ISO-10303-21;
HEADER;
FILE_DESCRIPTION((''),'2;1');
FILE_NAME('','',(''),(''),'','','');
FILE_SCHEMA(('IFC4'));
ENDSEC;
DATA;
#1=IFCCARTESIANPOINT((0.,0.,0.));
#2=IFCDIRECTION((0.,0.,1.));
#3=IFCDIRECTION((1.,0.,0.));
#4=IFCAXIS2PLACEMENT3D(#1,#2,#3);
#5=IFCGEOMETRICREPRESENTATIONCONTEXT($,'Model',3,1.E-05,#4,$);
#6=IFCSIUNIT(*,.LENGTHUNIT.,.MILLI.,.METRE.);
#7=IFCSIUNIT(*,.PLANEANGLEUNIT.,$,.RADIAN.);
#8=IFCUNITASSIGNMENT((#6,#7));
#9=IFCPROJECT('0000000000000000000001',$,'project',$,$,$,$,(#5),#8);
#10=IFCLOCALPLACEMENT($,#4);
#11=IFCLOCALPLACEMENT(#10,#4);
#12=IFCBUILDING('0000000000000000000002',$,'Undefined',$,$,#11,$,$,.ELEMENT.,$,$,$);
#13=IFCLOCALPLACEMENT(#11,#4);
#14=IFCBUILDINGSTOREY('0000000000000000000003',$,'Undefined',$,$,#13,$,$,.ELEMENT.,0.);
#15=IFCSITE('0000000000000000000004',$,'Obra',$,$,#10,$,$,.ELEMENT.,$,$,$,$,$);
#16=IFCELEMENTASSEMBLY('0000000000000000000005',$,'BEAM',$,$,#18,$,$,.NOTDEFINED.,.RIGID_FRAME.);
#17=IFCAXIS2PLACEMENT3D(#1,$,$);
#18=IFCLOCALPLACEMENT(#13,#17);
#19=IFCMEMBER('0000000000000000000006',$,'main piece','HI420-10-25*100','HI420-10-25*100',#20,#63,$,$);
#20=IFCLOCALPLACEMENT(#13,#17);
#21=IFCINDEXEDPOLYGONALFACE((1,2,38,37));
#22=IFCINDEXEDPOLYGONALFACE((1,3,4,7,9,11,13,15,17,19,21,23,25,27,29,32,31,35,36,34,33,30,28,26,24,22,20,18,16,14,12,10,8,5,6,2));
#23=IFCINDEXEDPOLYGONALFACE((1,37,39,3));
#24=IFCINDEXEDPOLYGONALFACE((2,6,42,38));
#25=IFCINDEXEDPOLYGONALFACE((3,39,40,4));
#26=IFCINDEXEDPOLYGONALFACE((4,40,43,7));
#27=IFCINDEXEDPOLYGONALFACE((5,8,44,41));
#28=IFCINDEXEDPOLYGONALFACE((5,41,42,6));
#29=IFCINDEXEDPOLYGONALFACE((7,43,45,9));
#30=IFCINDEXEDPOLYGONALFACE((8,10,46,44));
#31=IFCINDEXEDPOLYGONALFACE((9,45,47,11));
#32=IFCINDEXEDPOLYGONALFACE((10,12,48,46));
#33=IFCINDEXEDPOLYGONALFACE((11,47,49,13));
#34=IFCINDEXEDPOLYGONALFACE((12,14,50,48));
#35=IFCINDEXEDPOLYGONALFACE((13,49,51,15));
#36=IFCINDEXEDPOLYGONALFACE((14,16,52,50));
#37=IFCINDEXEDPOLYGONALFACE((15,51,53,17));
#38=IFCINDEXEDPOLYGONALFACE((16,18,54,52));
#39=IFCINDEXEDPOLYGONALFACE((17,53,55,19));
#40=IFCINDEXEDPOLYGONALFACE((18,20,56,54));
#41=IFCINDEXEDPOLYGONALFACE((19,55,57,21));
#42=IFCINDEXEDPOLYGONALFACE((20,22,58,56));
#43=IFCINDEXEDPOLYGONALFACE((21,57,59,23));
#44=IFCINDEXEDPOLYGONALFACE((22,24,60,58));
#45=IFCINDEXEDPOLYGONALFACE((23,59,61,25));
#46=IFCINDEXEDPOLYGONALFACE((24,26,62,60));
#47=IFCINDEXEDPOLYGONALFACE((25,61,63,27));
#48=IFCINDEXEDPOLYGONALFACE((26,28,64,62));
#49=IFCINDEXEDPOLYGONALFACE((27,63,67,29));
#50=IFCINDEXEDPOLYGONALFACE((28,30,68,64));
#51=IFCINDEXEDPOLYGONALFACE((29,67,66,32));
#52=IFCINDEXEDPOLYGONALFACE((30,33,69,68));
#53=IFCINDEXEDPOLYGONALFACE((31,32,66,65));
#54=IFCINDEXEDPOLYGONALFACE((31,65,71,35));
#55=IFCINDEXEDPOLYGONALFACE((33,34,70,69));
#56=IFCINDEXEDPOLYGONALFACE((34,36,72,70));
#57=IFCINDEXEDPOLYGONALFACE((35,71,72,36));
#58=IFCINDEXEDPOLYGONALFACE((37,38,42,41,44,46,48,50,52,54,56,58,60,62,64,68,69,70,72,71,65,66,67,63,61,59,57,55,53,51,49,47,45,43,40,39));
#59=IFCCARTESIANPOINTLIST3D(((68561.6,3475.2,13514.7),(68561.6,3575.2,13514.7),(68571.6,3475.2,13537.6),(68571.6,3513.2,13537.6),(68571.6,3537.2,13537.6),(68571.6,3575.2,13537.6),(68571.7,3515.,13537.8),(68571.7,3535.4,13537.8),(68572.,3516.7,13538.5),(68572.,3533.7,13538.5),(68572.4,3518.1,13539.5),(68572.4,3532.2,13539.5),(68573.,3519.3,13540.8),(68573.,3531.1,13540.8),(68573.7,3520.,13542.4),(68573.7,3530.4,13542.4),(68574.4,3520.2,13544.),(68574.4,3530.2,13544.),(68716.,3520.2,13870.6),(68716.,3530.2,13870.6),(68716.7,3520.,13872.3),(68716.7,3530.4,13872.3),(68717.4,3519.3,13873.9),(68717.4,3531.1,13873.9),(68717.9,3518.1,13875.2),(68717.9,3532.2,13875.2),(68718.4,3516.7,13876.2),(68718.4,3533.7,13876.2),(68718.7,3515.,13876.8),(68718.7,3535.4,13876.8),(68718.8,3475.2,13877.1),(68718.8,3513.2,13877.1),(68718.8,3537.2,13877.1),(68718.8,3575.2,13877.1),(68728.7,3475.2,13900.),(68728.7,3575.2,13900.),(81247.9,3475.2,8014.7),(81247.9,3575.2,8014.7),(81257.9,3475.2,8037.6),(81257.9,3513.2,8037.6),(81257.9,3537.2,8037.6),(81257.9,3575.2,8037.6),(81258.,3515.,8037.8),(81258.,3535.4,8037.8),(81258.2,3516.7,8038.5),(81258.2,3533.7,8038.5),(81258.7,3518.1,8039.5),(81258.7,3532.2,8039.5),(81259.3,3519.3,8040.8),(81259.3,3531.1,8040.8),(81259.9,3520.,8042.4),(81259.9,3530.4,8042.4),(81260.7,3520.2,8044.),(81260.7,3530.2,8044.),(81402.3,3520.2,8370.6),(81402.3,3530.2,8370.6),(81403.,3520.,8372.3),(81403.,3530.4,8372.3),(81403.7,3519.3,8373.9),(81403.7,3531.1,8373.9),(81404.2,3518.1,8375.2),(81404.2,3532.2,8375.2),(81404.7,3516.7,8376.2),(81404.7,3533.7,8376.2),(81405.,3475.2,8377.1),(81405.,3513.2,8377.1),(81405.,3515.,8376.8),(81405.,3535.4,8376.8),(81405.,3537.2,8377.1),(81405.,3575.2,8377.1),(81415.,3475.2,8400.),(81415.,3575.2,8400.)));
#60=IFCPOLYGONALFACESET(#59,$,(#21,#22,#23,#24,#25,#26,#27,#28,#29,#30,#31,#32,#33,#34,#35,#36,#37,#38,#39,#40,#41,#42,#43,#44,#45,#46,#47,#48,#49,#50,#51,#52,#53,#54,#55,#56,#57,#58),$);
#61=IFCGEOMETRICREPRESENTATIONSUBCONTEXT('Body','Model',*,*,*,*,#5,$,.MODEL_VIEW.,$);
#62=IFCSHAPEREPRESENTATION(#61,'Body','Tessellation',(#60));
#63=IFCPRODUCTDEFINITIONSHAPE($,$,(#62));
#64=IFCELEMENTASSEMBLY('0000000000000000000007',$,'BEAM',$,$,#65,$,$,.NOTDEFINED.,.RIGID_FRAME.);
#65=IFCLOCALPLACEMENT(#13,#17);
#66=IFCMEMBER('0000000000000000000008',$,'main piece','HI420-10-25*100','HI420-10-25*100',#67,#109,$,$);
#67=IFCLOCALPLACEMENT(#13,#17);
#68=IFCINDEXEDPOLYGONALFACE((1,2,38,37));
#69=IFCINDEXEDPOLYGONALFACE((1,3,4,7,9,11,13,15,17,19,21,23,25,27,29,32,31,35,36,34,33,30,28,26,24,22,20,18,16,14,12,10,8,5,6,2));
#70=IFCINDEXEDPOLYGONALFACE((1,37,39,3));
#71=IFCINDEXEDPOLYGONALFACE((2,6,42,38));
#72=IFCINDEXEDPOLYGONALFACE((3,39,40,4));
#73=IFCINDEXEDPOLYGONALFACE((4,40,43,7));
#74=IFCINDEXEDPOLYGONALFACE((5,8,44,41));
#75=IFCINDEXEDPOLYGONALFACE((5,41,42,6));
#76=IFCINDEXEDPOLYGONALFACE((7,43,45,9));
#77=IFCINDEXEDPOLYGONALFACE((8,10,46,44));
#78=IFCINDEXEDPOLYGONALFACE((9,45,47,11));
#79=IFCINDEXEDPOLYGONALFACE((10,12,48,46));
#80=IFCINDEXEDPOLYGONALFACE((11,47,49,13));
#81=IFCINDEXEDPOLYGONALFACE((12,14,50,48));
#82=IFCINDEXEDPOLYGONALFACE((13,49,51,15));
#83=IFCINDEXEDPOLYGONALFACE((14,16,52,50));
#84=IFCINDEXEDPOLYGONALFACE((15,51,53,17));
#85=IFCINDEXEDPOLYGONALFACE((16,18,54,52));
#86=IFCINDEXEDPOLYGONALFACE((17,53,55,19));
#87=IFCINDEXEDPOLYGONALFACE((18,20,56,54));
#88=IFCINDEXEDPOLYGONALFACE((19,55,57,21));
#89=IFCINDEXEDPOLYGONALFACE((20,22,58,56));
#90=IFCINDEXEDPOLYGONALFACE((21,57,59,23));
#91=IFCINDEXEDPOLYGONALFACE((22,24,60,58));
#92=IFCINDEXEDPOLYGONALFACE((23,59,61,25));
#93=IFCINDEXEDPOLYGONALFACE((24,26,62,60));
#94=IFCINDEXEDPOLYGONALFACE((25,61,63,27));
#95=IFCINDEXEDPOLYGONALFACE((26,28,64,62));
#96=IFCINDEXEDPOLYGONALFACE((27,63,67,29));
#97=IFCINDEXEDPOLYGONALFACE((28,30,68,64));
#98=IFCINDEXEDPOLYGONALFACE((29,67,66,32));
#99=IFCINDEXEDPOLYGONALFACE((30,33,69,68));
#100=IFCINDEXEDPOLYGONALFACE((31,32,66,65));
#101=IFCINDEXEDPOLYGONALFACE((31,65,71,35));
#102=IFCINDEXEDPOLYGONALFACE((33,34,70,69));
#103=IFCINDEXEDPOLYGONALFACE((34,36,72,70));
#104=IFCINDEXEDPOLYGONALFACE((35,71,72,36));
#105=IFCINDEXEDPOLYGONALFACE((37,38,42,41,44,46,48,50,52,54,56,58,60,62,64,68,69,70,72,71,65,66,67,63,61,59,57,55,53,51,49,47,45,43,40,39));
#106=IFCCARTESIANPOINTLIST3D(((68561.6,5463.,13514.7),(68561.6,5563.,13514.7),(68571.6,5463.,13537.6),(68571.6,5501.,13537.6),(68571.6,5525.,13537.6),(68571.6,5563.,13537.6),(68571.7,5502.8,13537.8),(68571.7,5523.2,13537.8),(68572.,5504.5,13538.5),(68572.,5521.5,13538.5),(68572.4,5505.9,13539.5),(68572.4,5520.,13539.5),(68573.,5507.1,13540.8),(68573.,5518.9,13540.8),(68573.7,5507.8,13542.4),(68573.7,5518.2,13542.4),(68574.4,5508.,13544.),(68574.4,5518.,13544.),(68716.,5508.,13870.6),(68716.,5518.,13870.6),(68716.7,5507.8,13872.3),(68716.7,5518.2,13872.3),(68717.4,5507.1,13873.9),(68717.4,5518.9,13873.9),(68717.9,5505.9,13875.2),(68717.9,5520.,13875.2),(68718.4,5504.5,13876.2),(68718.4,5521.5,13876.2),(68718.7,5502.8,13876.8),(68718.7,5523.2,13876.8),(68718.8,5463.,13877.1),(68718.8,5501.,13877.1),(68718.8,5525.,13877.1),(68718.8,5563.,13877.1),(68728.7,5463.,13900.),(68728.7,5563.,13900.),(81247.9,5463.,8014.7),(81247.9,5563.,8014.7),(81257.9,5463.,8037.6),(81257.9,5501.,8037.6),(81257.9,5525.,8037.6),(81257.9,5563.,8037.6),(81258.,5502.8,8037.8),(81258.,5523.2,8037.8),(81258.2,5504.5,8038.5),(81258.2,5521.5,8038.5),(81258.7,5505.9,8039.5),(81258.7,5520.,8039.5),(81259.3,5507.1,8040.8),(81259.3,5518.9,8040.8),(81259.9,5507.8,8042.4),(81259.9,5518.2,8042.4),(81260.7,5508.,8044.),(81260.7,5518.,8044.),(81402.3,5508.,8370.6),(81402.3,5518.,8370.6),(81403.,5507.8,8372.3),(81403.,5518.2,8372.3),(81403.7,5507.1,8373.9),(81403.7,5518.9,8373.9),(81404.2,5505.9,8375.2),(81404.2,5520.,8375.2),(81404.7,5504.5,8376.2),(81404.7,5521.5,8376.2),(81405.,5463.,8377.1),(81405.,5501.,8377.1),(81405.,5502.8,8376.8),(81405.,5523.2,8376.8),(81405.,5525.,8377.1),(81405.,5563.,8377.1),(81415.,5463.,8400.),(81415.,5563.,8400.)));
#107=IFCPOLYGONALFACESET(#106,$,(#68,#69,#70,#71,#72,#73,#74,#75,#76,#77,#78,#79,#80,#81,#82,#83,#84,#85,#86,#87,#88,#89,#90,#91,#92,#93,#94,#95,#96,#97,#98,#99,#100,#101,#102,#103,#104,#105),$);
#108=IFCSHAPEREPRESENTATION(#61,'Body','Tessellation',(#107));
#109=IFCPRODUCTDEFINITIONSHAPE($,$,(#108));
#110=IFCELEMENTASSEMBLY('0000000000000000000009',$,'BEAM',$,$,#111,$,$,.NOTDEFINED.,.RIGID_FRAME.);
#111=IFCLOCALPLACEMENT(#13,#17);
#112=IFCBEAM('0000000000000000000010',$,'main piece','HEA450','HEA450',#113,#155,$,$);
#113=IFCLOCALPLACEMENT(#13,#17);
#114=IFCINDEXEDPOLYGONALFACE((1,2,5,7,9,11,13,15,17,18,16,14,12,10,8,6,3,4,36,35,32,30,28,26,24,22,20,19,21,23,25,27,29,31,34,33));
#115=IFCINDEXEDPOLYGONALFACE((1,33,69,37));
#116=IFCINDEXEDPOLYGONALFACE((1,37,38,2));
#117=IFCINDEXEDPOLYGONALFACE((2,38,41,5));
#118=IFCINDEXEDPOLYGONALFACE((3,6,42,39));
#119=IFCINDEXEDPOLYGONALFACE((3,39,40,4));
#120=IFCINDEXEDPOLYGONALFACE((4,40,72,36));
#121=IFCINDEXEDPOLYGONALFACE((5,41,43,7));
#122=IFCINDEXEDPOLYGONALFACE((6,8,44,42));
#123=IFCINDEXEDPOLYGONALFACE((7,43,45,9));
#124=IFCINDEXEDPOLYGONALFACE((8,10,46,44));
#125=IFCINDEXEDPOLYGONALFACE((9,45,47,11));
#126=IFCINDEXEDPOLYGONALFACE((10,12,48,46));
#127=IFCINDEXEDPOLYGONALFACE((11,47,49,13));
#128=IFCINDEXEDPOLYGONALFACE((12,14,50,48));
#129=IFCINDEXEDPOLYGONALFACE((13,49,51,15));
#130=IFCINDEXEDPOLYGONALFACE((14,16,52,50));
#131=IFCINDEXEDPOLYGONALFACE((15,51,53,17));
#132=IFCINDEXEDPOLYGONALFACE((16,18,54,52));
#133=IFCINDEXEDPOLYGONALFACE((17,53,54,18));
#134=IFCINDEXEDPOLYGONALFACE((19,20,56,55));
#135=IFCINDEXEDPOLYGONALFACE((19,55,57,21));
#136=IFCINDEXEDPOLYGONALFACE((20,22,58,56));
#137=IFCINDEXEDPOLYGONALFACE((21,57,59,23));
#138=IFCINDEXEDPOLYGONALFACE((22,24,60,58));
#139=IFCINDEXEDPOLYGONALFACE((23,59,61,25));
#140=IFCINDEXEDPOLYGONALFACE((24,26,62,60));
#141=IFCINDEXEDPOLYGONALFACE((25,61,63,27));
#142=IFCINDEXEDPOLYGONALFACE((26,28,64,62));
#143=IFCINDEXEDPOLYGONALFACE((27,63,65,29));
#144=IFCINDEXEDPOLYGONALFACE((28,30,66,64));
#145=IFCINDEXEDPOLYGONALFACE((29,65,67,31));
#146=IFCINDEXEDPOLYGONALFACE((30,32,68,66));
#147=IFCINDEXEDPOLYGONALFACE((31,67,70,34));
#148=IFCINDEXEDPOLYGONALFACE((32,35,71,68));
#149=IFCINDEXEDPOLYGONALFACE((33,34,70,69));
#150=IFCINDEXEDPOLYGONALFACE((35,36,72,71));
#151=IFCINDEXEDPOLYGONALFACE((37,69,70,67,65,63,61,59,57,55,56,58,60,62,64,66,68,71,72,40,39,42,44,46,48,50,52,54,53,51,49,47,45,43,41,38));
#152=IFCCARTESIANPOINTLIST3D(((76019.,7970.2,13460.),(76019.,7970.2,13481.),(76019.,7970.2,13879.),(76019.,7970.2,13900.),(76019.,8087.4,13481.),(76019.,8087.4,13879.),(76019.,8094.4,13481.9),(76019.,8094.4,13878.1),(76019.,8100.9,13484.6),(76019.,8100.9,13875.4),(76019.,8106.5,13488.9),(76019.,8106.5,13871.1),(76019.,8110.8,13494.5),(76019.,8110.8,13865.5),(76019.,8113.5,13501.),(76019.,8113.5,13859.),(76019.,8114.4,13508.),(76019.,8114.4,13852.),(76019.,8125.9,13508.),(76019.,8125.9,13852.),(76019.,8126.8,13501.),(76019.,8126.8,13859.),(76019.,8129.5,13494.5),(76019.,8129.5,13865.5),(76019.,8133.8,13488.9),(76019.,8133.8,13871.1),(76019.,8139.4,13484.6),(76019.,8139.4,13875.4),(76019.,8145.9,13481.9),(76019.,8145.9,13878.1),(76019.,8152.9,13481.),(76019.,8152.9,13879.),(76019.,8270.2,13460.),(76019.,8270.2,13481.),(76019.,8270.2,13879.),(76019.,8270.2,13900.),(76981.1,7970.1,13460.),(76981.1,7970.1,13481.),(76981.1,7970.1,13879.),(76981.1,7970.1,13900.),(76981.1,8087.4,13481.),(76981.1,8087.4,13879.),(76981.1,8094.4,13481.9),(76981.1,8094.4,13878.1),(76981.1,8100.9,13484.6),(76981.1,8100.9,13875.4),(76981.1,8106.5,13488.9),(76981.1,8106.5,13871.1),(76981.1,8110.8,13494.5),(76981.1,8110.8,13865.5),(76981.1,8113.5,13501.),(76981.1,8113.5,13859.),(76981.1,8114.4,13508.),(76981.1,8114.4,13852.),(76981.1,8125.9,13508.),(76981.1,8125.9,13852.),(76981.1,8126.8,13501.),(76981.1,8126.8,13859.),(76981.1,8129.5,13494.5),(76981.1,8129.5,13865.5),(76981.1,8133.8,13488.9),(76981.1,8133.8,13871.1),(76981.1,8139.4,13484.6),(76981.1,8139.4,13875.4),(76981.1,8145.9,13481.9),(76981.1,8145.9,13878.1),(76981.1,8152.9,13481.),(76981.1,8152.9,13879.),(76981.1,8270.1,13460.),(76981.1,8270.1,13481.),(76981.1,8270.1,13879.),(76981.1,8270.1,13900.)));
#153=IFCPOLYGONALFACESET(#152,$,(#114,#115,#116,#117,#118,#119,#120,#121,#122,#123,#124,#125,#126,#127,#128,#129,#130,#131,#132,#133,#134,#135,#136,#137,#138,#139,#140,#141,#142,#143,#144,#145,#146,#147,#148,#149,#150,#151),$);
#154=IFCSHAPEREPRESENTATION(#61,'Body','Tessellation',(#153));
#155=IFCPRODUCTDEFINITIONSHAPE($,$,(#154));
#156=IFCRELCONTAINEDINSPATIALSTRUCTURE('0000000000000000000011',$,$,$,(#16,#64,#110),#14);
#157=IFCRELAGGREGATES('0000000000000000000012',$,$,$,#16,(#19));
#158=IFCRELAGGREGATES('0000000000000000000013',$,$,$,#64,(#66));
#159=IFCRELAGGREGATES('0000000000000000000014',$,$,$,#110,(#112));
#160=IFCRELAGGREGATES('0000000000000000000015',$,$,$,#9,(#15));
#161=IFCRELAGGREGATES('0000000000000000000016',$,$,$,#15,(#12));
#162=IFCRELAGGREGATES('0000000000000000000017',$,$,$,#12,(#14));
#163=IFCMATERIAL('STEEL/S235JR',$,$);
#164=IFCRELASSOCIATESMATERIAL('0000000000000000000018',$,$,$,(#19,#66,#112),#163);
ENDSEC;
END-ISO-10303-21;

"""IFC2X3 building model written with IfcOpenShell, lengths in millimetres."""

from ifc_helpers import new_model, si_unit, frame, origin_with_axes, origin_2d_with_axis, place, context, subcontext, project, spatial, i_section, extrude, clip, halfspace, material, element, aggregate, save


model = new_model("IFC2X3")

# Units and contexts
model_context = context("Model", 3, precision=1e-05, world=origin_with_axes())
body_context = subcontext(model_context, "Body", "Model", "MODEL_VIEW")
ifc_project = project(units=[si_unit("LENGTHUNIT", "METRE", prefix="MILLI"), si_unit("PLANEANGLEUNIT", "RADIAN")], contexts=[model_context])

# Site, building, storey
site_placement = place(None, origin_with_axes())
site = spatial("IfcSite", under=ifc_project, at=site_placement, Name="Obra", CompositionType="ELEMENT")
building_placement = place(site_placement, origin_with_axes())
building = spatial("IfcBuilding", under=site, at=building_placement, Name="Undefined", CompositionType="ELEMENT")
storey_placement = place(building_placement, origin_with_axes())
storey = spatial("IfcBuildingStorey", under=building, at=storey_placement, Name="Undefined", CompositionType="ELEMENT", Elevation=0.0)

# Element assemblies, members
assembly_1_placement = place(storey_placement, origin_with_axes())
assembly_1 = element("IfcElementAssembly", 1, at=assembly_1_placement, inside=storey, Name="BEAM", AssemblyPlace="NOTDEFINED", PredefinedType="RIGID_FRAME")
ifc_material_1 = material(Name="STEEL/S235JR")
member_1_placement = place(assembly_1_placement, frame((68645.2, 3525.2, 13707.3), z_axis=(0.397766, 0.0, 0.917487), x_axis=(0.917487, 0.0, -0.397766)))
member_1 = element("IfcMember", 2, at=member_1_placement, material=ifc_material_1, Name="main piece", Description="HI420-10-25*100", ObjectType="HI420-10-25*100", context=body_context, shape_type="SweptSolid", body=[
    extrude(i_section(OverallWidth=100.0, OverallDepth=420.0, WebThickness=10.0, FlangeThickness=25.0, FilletRadius=7.0, at=origin_2d_with_axis()), frame((13827.2, 0.0, 0.0), z_axis=(-1.0, 0.0, 0.0), x_axis=(0.0, -1.0, 0.0)), (0.0, 0.0, 1.0), 13827.2),
])
aggregate(assembly_1, [member_1])
assembly_2_placement = place(storey_placement, origin_with_axes())
assembly_2 = element("IfcElementAssembly", 3, at=assembly_2_placement, inside=storey, Name="BEAM", AssemblyPlace="NOTDEFINED", PredefinedType="RIGID_FRAME")
member_2_placement = place(assembly_2_placement, frame((68645.2, 5513.0, 13707.3), z_axis=(0.397766, 0.0, 0.917487), x_axis=(0.917487, 0.0, -0.397766)))
member_2 = element("IfcMember", 4, at=member_2_placement, material=ifc_material_1, Name="main piece", Description="HI420-10-25*100", ObjectType="HI420-10-25*100", context=body_context, shape_type="SweptSolid", body=[
    extrude(i_section(OverallWidth=100.0, OverallDepth=420.0, WebThickness=10.0, FlangeThickness=25.0, FilletRadius=7.0, at=origin_2d_with_axis()), frame((13827.2, 0.0, 0.0), z_axis=(-1.0, 0.0, 0.0), x_axis=(0.0, -1.0, 0.0)), (0.0, 0.0, 1.0), 13827.2),
])
aggregate(assembly_2, [member_2])

# Element assembly, beam
assembly_3_placement = place(storey_placement, origin_with_axes())
assembly_3 = element("IfcElementAssembly", 5, at=assembly_3_placement, inside=storey, Name="BEAM", AssemblyPlace="NOTDEFINED", PredefinedType="RIGID_FRAME")
beam_1_placement = place(assembly_3_placement, frame((76019.0, 8120.2, 13680.0), z_axis=(0.0, 0.0, 1.0), x_axis=(1.0, -0.000027, 0.0)))
beam_1 = element("IfcBeam", 6, at=beam_1_placement, material=ifc_material_1, Name="main piece", Description="HEA450", ObjectType="HEA450", context=body_context, shape_type="Clipping", body=[
    clip(extrude(i_section(OverallWidth=300.0, OverallDepth=440.0, WebThickness=11.5, FlangeThickness=21.0, FilletRadius=27.0, at=origin_2d_with_axis()), frame((962.1, 0.0, 0.0), z_axis=(-1.0, 0.0, 0.0), x_axis=(0.0, -1.0, 0.0)), (0.0, 0.0, 1.0), 962.1), halfspace(frame((962.1, 0.0, -1000.0), z_axis=(-1.0, -0.000042, 0.0), x_axis=(-0.000042, 1.0, 0.0)), True)),
])
aggregate(assembly_3, [beam_1])

save(model, "model.ifc")
